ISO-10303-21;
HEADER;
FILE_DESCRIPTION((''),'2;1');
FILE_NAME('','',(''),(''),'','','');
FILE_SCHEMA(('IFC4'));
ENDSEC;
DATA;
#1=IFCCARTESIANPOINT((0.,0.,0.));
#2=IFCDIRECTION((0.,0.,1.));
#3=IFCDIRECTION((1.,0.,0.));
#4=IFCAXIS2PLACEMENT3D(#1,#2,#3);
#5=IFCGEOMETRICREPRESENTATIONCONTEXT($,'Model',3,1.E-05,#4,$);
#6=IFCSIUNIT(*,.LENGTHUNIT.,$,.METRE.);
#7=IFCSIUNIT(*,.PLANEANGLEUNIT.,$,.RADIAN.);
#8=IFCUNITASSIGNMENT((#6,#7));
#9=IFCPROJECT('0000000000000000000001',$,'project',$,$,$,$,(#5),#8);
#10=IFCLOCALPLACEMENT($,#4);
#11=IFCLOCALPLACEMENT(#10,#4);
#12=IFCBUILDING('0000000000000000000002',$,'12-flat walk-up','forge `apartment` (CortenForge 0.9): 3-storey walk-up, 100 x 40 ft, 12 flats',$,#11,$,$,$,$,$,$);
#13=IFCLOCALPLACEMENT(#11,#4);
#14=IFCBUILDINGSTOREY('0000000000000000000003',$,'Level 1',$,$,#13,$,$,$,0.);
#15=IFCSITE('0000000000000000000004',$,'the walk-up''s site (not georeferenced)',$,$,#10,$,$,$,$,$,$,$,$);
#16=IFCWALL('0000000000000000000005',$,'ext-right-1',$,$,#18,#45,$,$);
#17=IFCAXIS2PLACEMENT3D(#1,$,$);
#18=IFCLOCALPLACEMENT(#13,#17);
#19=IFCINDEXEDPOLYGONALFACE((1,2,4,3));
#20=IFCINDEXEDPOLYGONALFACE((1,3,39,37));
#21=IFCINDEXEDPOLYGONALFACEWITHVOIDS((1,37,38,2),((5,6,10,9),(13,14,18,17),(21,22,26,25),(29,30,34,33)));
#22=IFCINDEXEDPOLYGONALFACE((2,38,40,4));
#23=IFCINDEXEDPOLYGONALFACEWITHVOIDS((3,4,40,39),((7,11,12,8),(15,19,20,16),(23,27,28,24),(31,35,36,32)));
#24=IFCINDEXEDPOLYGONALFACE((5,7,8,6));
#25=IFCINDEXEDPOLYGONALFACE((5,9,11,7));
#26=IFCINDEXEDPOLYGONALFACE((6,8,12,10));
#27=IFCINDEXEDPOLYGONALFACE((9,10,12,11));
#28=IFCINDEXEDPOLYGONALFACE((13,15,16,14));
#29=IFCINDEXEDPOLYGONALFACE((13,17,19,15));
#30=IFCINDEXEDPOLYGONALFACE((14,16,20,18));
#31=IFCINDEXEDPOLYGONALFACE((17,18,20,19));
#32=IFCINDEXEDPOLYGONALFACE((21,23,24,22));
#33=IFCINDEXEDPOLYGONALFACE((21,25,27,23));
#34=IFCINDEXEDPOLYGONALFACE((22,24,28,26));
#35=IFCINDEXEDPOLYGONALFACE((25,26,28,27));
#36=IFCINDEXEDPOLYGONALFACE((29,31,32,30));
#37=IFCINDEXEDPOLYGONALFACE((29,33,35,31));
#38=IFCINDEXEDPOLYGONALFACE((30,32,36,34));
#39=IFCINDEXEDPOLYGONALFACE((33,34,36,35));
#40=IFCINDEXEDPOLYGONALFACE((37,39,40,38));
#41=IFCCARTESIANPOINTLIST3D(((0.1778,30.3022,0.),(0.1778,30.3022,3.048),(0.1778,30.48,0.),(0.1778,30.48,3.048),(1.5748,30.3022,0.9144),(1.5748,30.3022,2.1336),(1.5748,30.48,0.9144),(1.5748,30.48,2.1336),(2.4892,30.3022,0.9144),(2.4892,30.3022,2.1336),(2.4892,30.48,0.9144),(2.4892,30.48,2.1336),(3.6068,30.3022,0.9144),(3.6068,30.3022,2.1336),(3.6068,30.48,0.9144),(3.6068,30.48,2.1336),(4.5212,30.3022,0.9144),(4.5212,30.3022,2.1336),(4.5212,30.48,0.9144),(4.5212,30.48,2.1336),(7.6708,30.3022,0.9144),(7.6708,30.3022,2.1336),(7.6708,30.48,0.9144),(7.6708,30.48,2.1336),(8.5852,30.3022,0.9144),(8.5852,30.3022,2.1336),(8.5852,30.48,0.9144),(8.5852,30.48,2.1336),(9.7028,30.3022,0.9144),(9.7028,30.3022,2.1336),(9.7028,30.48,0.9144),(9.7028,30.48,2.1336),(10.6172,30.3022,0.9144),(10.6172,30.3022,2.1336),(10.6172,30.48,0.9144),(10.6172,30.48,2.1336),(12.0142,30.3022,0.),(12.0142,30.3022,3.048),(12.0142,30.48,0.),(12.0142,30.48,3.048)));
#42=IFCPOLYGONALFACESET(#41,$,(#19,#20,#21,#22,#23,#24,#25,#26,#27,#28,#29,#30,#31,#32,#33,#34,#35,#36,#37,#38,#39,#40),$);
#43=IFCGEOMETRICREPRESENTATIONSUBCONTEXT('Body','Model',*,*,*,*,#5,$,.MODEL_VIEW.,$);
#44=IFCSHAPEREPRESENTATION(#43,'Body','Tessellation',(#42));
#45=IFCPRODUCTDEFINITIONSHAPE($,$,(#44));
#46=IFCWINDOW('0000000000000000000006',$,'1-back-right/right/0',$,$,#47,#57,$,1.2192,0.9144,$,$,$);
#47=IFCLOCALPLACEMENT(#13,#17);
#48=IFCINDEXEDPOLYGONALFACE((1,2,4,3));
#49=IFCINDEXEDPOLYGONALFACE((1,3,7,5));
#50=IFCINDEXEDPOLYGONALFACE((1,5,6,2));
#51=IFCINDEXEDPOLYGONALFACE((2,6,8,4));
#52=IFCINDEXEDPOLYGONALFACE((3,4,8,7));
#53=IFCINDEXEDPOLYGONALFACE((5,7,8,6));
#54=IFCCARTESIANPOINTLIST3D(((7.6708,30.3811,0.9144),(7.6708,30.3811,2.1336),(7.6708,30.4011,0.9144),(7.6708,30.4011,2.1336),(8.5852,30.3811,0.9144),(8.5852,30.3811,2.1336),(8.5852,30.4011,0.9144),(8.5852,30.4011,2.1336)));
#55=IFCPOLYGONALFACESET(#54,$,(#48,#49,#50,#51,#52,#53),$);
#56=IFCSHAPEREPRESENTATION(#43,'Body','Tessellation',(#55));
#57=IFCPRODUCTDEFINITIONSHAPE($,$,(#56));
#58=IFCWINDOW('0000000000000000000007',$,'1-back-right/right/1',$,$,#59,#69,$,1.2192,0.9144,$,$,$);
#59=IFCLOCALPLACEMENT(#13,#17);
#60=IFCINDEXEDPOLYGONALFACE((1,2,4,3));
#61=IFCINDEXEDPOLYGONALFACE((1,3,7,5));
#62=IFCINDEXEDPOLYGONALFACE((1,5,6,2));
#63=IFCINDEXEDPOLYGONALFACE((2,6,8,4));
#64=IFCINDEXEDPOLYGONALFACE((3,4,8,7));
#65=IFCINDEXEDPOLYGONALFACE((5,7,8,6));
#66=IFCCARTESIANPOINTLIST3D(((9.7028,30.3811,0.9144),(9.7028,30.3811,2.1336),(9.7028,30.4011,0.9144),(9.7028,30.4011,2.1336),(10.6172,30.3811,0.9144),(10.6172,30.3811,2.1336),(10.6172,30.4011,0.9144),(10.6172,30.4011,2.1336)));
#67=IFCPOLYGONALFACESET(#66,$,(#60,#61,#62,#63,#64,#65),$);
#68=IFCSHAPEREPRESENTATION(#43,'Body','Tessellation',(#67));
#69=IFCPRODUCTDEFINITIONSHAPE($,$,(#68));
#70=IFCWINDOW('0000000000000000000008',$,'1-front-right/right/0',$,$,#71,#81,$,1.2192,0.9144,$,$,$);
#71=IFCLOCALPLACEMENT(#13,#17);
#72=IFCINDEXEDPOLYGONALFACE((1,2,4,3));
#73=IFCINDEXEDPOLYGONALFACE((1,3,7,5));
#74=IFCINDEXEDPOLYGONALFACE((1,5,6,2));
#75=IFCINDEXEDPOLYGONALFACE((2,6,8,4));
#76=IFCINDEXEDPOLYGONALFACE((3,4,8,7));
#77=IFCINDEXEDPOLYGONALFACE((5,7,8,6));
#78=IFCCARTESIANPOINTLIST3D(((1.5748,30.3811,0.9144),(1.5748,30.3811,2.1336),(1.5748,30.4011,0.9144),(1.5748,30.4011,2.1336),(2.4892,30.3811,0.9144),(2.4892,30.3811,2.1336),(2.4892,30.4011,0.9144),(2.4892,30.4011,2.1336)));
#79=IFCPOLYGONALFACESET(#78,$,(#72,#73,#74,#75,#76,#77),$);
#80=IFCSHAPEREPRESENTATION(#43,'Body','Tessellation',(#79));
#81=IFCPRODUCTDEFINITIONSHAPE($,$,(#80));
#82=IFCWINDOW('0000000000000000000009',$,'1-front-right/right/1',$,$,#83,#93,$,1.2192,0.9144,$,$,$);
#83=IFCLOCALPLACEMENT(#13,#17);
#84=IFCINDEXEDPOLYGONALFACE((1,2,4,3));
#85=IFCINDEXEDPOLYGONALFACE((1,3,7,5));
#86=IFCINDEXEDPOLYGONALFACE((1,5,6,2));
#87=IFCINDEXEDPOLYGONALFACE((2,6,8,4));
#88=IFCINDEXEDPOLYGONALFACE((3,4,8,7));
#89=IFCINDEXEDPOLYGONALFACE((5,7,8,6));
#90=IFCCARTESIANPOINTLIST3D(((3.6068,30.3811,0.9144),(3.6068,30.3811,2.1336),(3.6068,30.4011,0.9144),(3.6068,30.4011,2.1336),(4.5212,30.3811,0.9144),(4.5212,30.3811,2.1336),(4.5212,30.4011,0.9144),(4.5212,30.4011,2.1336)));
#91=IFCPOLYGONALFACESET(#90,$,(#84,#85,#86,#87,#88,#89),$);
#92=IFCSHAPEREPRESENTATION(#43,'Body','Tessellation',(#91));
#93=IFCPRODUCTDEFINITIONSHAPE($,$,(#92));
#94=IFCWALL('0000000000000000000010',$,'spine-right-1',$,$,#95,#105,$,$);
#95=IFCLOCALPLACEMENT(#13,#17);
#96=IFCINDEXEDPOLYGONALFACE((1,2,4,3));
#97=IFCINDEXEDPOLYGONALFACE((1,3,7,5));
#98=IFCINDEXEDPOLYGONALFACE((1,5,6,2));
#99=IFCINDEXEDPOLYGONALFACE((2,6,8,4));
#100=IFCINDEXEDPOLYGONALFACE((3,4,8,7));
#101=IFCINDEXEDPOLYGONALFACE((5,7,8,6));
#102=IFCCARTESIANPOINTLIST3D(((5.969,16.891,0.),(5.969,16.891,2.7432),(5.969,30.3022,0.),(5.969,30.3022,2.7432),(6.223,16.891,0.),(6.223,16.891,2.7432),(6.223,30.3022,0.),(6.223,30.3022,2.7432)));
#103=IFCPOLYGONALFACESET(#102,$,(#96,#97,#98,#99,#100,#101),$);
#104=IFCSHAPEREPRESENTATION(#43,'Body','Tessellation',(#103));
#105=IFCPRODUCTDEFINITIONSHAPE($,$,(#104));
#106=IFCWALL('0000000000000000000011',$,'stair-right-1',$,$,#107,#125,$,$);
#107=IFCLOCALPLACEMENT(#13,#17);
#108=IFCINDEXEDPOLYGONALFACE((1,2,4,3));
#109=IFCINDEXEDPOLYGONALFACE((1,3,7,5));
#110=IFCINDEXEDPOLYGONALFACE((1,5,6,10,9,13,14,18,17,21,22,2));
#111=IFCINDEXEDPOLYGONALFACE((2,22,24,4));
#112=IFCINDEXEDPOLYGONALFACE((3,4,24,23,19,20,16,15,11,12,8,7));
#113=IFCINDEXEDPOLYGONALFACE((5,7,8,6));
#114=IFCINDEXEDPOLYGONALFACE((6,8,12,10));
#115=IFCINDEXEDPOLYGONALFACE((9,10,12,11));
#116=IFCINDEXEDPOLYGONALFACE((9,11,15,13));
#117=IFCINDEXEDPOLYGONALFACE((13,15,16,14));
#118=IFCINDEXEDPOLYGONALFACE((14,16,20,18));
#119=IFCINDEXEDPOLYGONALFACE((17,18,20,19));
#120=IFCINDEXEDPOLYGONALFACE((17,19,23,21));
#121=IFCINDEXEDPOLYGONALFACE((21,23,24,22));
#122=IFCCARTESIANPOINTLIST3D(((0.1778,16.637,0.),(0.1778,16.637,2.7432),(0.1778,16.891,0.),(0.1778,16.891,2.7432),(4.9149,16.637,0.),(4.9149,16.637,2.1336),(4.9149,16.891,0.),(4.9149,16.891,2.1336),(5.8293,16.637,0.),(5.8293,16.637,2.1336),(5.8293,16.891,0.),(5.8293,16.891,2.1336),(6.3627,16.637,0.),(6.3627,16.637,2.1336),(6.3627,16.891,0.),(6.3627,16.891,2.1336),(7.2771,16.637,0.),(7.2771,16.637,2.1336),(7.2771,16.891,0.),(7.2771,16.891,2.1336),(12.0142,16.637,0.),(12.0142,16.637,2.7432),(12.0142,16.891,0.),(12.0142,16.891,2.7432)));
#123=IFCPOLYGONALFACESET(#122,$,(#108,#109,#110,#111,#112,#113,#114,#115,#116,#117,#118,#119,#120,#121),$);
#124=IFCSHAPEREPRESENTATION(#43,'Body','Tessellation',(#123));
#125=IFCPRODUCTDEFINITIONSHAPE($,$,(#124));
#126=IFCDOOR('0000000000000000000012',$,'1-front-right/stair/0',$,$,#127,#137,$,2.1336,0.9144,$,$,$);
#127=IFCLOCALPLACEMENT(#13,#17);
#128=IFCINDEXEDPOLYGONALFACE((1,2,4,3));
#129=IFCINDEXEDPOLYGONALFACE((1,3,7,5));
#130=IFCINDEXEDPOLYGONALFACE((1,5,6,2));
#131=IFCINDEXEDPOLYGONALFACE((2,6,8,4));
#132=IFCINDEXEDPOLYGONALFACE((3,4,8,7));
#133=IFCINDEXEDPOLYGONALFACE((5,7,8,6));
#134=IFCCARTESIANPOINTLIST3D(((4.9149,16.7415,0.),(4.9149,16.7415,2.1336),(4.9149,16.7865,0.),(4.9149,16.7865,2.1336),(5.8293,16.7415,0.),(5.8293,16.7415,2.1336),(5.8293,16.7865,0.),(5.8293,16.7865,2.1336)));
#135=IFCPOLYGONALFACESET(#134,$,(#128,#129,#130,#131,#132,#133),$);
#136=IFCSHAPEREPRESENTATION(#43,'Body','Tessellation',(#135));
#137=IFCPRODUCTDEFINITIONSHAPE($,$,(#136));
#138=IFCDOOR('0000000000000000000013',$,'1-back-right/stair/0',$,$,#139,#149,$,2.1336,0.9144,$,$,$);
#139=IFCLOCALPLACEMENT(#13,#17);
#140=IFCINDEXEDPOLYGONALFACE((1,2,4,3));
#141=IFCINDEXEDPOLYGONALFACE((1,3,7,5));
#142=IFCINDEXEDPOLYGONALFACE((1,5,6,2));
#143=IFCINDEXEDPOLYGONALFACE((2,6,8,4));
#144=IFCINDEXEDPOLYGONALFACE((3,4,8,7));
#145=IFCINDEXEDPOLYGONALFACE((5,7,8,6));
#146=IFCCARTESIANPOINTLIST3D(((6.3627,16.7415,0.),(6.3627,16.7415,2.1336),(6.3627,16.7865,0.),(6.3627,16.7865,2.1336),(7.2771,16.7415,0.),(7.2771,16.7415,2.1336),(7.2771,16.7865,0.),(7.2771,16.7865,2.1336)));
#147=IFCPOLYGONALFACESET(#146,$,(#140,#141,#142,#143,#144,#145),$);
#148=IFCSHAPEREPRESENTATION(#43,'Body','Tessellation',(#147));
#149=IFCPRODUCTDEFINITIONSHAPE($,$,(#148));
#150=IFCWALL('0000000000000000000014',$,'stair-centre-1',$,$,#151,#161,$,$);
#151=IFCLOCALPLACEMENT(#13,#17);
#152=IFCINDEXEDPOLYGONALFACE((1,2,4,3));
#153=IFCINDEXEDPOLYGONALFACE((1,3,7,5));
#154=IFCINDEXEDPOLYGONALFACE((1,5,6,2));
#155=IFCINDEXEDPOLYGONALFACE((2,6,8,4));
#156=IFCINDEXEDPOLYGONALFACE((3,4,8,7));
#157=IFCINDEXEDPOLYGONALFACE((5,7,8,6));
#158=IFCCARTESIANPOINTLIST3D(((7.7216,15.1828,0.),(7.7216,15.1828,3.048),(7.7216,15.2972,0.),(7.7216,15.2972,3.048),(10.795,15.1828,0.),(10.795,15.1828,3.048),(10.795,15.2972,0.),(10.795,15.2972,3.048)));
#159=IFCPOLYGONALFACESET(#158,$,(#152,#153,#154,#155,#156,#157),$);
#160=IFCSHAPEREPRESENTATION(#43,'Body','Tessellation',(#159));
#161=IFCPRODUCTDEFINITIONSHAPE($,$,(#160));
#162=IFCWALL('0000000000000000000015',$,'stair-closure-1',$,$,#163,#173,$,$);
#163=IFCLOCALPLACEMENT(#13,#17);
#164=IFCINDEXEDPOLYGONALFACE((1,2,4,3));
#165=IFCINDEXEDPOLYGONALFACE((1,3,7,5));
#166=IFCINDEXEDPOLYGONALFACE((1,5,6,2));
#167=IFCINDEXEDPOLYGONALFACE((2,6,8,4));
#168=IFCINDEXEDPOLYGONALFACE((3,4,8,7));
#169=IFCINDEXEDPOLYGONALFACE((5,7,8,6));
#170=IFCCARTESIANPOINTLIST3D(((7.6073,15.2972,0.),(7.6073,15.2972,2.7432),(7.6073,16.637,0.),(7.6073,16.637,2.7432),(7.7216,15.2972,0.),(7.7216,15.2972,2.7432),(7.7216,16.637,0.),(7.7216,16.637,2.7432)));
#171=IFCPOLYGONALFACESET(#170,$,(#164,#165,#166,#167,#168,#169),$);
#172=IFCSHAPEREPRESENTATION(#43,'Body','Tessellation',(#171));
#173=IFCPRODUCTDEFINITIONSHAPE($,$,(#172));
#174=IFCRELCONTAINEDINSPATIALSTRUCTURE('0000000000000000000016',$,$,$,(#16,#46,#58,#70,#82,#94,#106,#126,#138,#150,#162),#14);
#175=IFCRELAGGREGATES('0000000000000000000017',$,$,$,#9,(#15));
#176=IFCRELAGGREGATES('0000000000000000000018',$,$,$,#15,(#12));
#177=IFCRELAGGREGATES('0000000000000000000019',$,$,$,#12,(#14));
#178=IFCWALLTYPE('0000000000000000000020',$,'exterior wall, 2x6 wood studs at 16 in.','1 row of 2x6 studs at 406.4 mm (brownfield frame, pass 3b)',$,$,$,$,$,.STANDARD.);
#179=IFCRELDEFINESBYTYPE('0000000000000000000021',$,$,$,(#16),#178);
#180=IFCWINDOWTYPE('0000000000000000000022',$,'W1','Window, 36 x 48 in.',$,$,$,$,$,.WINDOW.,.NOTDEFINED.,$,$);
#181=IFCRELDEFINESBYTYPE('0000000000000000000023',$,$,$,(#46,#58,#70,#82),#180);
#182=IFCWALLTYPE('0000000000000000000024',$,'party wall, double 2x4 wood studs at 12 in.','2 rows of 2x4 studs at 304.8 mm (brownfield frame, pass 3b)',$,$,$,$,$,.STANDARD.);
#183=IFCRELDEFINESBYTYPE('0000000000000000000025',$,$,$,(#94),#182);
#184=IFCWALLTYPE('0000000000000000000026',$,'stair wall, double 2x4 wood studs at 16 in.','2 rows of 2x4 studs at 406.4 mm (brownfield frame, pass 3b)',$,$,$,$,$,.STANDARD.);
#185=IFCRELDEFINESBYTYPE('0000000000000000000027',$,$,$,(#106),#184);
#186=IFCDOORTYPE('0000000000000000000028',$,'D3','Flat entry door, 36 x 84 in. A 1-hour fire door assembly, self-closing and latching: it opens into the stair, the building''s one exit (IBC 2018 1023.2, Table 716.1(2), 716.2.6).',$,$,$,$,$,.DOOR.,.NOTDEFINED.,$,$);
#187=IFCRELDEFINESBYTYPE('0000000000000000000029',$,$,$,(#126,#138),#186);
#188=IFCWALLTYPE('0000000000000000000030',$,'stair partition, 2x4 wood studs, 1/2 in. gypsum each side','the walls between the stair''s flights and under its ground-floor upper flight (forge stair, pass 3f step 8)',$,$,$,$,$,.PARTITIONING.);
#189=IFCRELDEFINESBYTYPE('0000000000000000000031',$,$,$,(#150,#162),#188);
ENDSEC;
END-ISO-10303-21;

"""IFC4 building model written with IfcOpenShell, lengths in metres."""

from ifc_helpers import new_model, si_unit, frame, frame_2d, origin, origin_with_axes, place, context, subcontext, project, spatial, rectangle, extrude, type_object, element, fill, save


model = new_model("IFC4")

# Units and contexts
model_context = context("Model", 3, precision=1e-05, world=origin_with_axes())
body_context = subcontext(model_context, "Body", "Model", "MODEL_VIEW")
ifc_project = project(units=[si_unit("LENGTHUNIT", "METRE"), si_unit("PLANEANGLEUNIT", "RADIAN")], contexts=[model_context])

# Site, building, storey
site_placement = place(None, origin_with_axes())
site = spatial("IfcSite", under=ifc_project, at=site_placement, Name="the walk-up's site (not georeferenced)")
building_placement = place(site_placement, origin_with_axes())
building = spatial("IfcBuilding", under=site, at=building_placement, Name="12-flat walk-up", Description="forge `apartment` (CortenForge 0.9): 3-storey walk-up, 100 x 40 ft, 12 flats")
storey_placement = place(building_placement, origin_with_axes())
storey = spatial("IfcBuildingStorey", under=building, at=storey_placement, Name="Level 1", Elevation=0.0)

# Wall, openings, windows
wall_type_1 = type_object("IfcWallType", Name="exterior wall, 2x6 wood studs at 16 in.", Description="1 row of 2x6 studs at 406.4 mm (brownfield frame, pass 3b)", PredefinedType="STANDARD")
wall_1_placement = place(storey_placement, frame((0.1778, 30.3022, 0.0), z_axis=(0.0, 0.0, 1.0), x_axis=(1.0, 0.0, 0.0)))
wall_1 = element("IfcWall", 1, at=wall_1_placement, inside=storey, type_object=wall_type_1, Name="ext-right-1", context=body_context, shape_type="SweptSolid", body=[
    extrude(rectangle(XDim=11.8364, YDim=0.1778, at=frame_2d((5.9182, 0.0889))), origin(), (0.0, 0.0, 1.0), 3.048),
])
opening_1_placement = place(wall_1_placement, frame((8.4074, 0.1778, 0.9144), z_axis=(0.0, 0.0, 1.0), x_axis=(-1.0, 0.0, 0.0)))
opening_1 = element("IfcOpeningElement", 2, at=opening_1_placement, cuts=wall_1, PredefinedType="OPENING", context=body_context, shape_type="SweptSolid", body=[
    extrude(rectangle(XDim=0.9144, YDim=0.1778, at=frame_2d((0.4572, 0.0889))), origin(), (0.0, 0.0, 1.0), 1.2192),
])
opening_2_placement = place(wall_1_placement, frame((10.4394, 0.1778, 0.9144), z_axis=(0.0, 0.0, 1.0), x_axis=(-1.0, 0.0, 0.0)))
opening_2 = element("IfcOpeningElement", 3, at=opening_2_placement, cuts=wall_1, PredefinedType="OPENING", context=body_context, shape_type="SweptSolid", body=[
    extrude(rectangle(XDim=0.9144, YDim=0.1778, at=frame_2d((0.4572, 0.0889))), origin(), (0.0, 0.0, 1.0), 1.2192),
])
opening_3_placement = place(wall_1_placement, frame((2.3114, 0.1778, 0.9144), z_axis=(0.0, 0.0, 1.0), x_axis=(-1.0, 0.0, 0.0)))
opening_3 = element("IfcOpeningElement", 4, at=opening_3_placement, cuts=wall_1, PredefinedType="OPENING", context=body_context, shape_type="SweptSolid", body=[
    extrude(rectangle(XDim=0.9144, YDim=0.1778, at=frame_2d((0.4572, 0.0889))), origin(), (0.0, 0.0, 1.0), 1.2192),
])
opening_4_placement = place(wall_1_placement, frame((4.3434, 0.1778, 0.9144), z_axis=(0.0, 0.0, 1.0), x_axis=(-1.0, 0.0, 0.0)))
opening_4 = element("IfcOpeningElement", 5, at=opening_4_placement, cuts=wall_1, PredefinedType="OPENING", context=body_context, shape_type="SweptSolid", body=[
    extrude(rectangle(XDim=0.9144, YDim=0.1778, at=frame_2d((0.4572, 0.0889))), origin(), (0.0, 0.0, 1.0), 1.2192),
])
window_type = type_object("IfcWindowType", Name="W1", Description="Window, 36 x 48 in.", PartitioningType="NOTDEFINED", PredefinedType="WINDOW")
window_1_placement = place(opening_1_placement, frame((0.0, 0.0789, 0.0), z_axis=(0.0, 0.0, 1.0), x_axis=(1.0, 0.0, 0.0)))
window_1 = element("IfcWindow", 6, at=window_1_placement, inside=storey, type_object=window_type, Name="1-back-right/right/0", OverallHeight=1.2192, OverallWidth=0.9144, context=body_context, shape_type="SweptSolid", body=[
    extrude(rectangle(XDim=0.9144, YDim=0.02, at=frame_2d((0.4572, 0.01))), origin(), (0.0, 0.0, 1.0), 1.2192),
])
fill(opening_1, window_1)
window_2_placement = place(opening_2_placement, frame((0.0, 0.0789, 0.0), z_axis=(0.0, 0.0, 1.0), x_axis=(1.0, 0.0, 0.0)))
window_2 = element("IfcWindow", 7, at=window_2_placement, inside=storey, type_object=window_type, Name="1-back-right/right/1", OverallHeight=1.2192, OverallWidth=0.9144, context=body_context, shape_type="SweptSolid", body=[
    extrude(rectangle(XDim=0.9144, YDim=0.02, at=frame_2d((0.4572, 0.01))), origin(), (0.0, 0.0, 1.0), 1.2192),
])
fill(opening_2, window_2)
window_3_placement = place(opening_3_placement, frame((0.0, 0.0789, 0.0), z_axis=(0.0, 0.0, 1.0), x_axis=(1.0, 0.0, 0.0)))
window_3 = element("IfcWindow", 8, at=window_3_placement, inside=storey, type_object=window_type, Name="1-front-right/right/0", OverallHeight=1.2192, OverallWidth=0.9144, context=body_context, shape_type="SweptSolid", body=[
    extrude(rectangle(XDim=0.9144, YDim=0.02, at=frame_2d((0.4572, 0.01))), origin(), (0.0, 0.0, 1.0), 1.2192),
])
fill(opening_3, window_3)
window_4_placement = place(opening_4_placement, frame((0.0, 0.0789, 0.0), z_axis=(0.0, 0.0, 1.0), x_axis=(1.0, 0.0, 0.0)))
window_4 = element("IfcWindow", 9, at=window_4_placement, inside=storey, type_object=window_type, Name="1-front-right/right/1", OverallHeight=1.2192, OverallWidth=0.9144, context=body_context, shape_type="SweptSolid", body=[
    extrude(rectangle(XDim=0.9144, YDim=0.02, at=frame_2d((0.4572, 0.01))), origin(), (0.0, 0.0, 1.0), 1.2192),
])
fill(opening_4, window_4)

# Wall
wall_type_2 = type_object("IfcWallType", Name="party wall, double 2x4 wood studs at 12 in.", Description="2 rows of 2x4 studs at 304.8 mm (brownfield frame, pass 3b)", PredefinedType="STANDARD")
wall_2_placement = place(storey_placement, frame((5.969, 16.891, 0.0), z_axis=(0.0, 0.0, 1.0), x_axis=(1.0, 0.0, 0.0)))
element("IfcWall", 10, at=wall_2_placement, inside=storey, type_object=wall_type_2, Name="spine-right-1", context=body_context, shape_type="SweptSolid", body=[
    extrude(rectangle(XDim=0.254, YDim=13.4112, at=frame_2d((0.127, 6.7056))), origin(), (0.0, 0.0, 1.0), 2.7432),
])

# Wall, openings, doors
wall_type_3 = type_object("IfcWallType", Name="stair wall, double 2x4 wood studs at 16 in.", Description="2 rows of 2x4 studs at 406.4 mm (brownfield frame, pass 3b)", PredefinedType="STANDARD")
wall_3_placement = place(storey_placement, frame((0.1778, 16.637, 0.0), z_axis=(0.0, 0.0, 1.0), x_axis=(1.0, 0.0, 0.0)))
wall_3 = element("IfcWall", 11, at=wall_3_placement, inside=storey, type_object=wall_type_3, Name="stair-right-1", context=body_context, shape_type="SweptSolid", body=[
    extrude(rectangle(XDim=11.8364, YDim=0.254, at=frame_2d((5.9182, 0.127))), origin(), (0.0, 0.0, 1.0), 2.7432),
])
opening_5_placement = place(wall_3_placement, frame((5.6515, 0.254, 0.0), z_axis=(0.0, 0.0, 1.0), x_axis=(-1.0, 0.0, 0.0)))
opening_5 = element("IfcOpeningElement", 12, at=opening_5_placement, cuts=wall_3, PredefinedType="OPENING", context=body_context, shape_type="SweptSolid", body=[
    extrude(rectangle(XDim=0.9144, YDim=0.254, at=frame_2d((0.4572, 0.127))), origin(), (0.0, 0.0, 1.0), 2.1336),
])
opening_6_placement = place(wall_3_placement, frame((7.0993, 0.254, 0.0), z_axis=(0.0, 0.0, 1.0), x_axis=(-1.0, 0.0, 0.0)))
opening_6 = element("IfcOpeningElement", 13, at=opening_6_placement, cuts=wall_3, PredefinedType="OPENING", context=body_context, shape_type="SweptSolid", body=[
    extrude(rectangle(XDim=0.9144, YDim=0.254, at=frame_2d((0.4572, 0.127))), origin(), (0.0, 0.0, 1.0), 2.1336),
])
door_type = type_object("IfcDoorType", Name="D3", Description="Flat entry door, 36 x 84 in. A 1-hour fire door assembly, self-closing and latching: it opens into the stair, the building's one exit (IBC 2018 1023.2, Table 716.1(2), 716.2.6).", OperationType="NOTDEFINED", PredefinedType="DOOR")
door_1_placement = place(opening_5_placement, frame((0.0, 0.1045, 0.0), z_axis=(0.0, 0.0, 1.0), x_axis=(1.0, 0.0, 0.0)))
door_1 = element("IfcDoor", 14, at=door_1_placement, inside=storey, type_object=door_type, Name="1-front-right/stair/0", OverallHeight=2.1336, OverallWidth=0.9144, context=body_context, shape_type="SweptSolid", body=[
    extrude(rectangle(XDim=0.9144, YDim=0.045, at=frame_2d((0.4572, 0.0225))), origin(), (0.0, 0.0, 1.0), 2.1336),
])
fill(opening_5, door_1)
door_2_placement = place(opening_6_placement, frame((0.0, 0.1045, 0.0), z_axis=(0.0, 0.0, 1.0), x_axis=(1.0, 0.0, 0.0)))
door_2 = element("IfcDoor", 15, at=door_2_placement, inside=storey, type_object=door_type, Name="1-back-right/stair/0", OverallHeight=2.1336, OverallWidth=0.9144, context=body_context, shape_type="SweptSolid", body=[
    extrude(rectangle(XDim=0.9144, YDim=0.045, at=frame_2d((0.4572, 0.0225))), origin(), (0.0, 0.0, 1.0), 2.1336),
])
fill(opening_6, door_2)

# Walls
wall_type_4 = type_object("IfcWallType", Name="stair partition, 2x4 wood studs, 1/2 in. gypsum each side", Description="the walls between the stair's flights and under its ground-floor upper flight (forge stair, pass 3f step 8)", PredefinedType="PARTITIONING")
wall_4_placement = place(storey_placement, frame((7.7216, 15.1829, 0.0), z_axis=(0.0, 0.0, 1.0), x_axis=(1.0, 0.0, 0.0)))
element("IfcWall", 16, at=wall_4_placement, inside=storey, type_object=wall_type_4, Name="stair-centre-1", context=body_context, shape_type="SweptSolid", body=[
    extrude(rectangle(XDim=3.0734, YDim=0.1143, at=frame_2d((1.5367, 0.0572))), origin(), (0.0, 0.0, 1.0), 3.048),
])
wall_5_placement = place(storey_placement, frame((7.6073, 15.2972, 0.0), z_axis=(0.0, 0.0, 1.0), x_axis=(1.0, 0.0, 0.0)))
element("IfcWall", 17, at=wall_5_placement, inside=storey, type_object=wall_type_4, Name="stair-closure-1", context=body_context, shape_type="SweptSolid", body=[
    extrude(rectangle(XDim=0.1143, YDim=1.3399, at=frame_2d((0.0571, 0.6699))), origin(), (0.0, 0.0, 1.0), 2.7432),
])

save(model, "model.ifc")
